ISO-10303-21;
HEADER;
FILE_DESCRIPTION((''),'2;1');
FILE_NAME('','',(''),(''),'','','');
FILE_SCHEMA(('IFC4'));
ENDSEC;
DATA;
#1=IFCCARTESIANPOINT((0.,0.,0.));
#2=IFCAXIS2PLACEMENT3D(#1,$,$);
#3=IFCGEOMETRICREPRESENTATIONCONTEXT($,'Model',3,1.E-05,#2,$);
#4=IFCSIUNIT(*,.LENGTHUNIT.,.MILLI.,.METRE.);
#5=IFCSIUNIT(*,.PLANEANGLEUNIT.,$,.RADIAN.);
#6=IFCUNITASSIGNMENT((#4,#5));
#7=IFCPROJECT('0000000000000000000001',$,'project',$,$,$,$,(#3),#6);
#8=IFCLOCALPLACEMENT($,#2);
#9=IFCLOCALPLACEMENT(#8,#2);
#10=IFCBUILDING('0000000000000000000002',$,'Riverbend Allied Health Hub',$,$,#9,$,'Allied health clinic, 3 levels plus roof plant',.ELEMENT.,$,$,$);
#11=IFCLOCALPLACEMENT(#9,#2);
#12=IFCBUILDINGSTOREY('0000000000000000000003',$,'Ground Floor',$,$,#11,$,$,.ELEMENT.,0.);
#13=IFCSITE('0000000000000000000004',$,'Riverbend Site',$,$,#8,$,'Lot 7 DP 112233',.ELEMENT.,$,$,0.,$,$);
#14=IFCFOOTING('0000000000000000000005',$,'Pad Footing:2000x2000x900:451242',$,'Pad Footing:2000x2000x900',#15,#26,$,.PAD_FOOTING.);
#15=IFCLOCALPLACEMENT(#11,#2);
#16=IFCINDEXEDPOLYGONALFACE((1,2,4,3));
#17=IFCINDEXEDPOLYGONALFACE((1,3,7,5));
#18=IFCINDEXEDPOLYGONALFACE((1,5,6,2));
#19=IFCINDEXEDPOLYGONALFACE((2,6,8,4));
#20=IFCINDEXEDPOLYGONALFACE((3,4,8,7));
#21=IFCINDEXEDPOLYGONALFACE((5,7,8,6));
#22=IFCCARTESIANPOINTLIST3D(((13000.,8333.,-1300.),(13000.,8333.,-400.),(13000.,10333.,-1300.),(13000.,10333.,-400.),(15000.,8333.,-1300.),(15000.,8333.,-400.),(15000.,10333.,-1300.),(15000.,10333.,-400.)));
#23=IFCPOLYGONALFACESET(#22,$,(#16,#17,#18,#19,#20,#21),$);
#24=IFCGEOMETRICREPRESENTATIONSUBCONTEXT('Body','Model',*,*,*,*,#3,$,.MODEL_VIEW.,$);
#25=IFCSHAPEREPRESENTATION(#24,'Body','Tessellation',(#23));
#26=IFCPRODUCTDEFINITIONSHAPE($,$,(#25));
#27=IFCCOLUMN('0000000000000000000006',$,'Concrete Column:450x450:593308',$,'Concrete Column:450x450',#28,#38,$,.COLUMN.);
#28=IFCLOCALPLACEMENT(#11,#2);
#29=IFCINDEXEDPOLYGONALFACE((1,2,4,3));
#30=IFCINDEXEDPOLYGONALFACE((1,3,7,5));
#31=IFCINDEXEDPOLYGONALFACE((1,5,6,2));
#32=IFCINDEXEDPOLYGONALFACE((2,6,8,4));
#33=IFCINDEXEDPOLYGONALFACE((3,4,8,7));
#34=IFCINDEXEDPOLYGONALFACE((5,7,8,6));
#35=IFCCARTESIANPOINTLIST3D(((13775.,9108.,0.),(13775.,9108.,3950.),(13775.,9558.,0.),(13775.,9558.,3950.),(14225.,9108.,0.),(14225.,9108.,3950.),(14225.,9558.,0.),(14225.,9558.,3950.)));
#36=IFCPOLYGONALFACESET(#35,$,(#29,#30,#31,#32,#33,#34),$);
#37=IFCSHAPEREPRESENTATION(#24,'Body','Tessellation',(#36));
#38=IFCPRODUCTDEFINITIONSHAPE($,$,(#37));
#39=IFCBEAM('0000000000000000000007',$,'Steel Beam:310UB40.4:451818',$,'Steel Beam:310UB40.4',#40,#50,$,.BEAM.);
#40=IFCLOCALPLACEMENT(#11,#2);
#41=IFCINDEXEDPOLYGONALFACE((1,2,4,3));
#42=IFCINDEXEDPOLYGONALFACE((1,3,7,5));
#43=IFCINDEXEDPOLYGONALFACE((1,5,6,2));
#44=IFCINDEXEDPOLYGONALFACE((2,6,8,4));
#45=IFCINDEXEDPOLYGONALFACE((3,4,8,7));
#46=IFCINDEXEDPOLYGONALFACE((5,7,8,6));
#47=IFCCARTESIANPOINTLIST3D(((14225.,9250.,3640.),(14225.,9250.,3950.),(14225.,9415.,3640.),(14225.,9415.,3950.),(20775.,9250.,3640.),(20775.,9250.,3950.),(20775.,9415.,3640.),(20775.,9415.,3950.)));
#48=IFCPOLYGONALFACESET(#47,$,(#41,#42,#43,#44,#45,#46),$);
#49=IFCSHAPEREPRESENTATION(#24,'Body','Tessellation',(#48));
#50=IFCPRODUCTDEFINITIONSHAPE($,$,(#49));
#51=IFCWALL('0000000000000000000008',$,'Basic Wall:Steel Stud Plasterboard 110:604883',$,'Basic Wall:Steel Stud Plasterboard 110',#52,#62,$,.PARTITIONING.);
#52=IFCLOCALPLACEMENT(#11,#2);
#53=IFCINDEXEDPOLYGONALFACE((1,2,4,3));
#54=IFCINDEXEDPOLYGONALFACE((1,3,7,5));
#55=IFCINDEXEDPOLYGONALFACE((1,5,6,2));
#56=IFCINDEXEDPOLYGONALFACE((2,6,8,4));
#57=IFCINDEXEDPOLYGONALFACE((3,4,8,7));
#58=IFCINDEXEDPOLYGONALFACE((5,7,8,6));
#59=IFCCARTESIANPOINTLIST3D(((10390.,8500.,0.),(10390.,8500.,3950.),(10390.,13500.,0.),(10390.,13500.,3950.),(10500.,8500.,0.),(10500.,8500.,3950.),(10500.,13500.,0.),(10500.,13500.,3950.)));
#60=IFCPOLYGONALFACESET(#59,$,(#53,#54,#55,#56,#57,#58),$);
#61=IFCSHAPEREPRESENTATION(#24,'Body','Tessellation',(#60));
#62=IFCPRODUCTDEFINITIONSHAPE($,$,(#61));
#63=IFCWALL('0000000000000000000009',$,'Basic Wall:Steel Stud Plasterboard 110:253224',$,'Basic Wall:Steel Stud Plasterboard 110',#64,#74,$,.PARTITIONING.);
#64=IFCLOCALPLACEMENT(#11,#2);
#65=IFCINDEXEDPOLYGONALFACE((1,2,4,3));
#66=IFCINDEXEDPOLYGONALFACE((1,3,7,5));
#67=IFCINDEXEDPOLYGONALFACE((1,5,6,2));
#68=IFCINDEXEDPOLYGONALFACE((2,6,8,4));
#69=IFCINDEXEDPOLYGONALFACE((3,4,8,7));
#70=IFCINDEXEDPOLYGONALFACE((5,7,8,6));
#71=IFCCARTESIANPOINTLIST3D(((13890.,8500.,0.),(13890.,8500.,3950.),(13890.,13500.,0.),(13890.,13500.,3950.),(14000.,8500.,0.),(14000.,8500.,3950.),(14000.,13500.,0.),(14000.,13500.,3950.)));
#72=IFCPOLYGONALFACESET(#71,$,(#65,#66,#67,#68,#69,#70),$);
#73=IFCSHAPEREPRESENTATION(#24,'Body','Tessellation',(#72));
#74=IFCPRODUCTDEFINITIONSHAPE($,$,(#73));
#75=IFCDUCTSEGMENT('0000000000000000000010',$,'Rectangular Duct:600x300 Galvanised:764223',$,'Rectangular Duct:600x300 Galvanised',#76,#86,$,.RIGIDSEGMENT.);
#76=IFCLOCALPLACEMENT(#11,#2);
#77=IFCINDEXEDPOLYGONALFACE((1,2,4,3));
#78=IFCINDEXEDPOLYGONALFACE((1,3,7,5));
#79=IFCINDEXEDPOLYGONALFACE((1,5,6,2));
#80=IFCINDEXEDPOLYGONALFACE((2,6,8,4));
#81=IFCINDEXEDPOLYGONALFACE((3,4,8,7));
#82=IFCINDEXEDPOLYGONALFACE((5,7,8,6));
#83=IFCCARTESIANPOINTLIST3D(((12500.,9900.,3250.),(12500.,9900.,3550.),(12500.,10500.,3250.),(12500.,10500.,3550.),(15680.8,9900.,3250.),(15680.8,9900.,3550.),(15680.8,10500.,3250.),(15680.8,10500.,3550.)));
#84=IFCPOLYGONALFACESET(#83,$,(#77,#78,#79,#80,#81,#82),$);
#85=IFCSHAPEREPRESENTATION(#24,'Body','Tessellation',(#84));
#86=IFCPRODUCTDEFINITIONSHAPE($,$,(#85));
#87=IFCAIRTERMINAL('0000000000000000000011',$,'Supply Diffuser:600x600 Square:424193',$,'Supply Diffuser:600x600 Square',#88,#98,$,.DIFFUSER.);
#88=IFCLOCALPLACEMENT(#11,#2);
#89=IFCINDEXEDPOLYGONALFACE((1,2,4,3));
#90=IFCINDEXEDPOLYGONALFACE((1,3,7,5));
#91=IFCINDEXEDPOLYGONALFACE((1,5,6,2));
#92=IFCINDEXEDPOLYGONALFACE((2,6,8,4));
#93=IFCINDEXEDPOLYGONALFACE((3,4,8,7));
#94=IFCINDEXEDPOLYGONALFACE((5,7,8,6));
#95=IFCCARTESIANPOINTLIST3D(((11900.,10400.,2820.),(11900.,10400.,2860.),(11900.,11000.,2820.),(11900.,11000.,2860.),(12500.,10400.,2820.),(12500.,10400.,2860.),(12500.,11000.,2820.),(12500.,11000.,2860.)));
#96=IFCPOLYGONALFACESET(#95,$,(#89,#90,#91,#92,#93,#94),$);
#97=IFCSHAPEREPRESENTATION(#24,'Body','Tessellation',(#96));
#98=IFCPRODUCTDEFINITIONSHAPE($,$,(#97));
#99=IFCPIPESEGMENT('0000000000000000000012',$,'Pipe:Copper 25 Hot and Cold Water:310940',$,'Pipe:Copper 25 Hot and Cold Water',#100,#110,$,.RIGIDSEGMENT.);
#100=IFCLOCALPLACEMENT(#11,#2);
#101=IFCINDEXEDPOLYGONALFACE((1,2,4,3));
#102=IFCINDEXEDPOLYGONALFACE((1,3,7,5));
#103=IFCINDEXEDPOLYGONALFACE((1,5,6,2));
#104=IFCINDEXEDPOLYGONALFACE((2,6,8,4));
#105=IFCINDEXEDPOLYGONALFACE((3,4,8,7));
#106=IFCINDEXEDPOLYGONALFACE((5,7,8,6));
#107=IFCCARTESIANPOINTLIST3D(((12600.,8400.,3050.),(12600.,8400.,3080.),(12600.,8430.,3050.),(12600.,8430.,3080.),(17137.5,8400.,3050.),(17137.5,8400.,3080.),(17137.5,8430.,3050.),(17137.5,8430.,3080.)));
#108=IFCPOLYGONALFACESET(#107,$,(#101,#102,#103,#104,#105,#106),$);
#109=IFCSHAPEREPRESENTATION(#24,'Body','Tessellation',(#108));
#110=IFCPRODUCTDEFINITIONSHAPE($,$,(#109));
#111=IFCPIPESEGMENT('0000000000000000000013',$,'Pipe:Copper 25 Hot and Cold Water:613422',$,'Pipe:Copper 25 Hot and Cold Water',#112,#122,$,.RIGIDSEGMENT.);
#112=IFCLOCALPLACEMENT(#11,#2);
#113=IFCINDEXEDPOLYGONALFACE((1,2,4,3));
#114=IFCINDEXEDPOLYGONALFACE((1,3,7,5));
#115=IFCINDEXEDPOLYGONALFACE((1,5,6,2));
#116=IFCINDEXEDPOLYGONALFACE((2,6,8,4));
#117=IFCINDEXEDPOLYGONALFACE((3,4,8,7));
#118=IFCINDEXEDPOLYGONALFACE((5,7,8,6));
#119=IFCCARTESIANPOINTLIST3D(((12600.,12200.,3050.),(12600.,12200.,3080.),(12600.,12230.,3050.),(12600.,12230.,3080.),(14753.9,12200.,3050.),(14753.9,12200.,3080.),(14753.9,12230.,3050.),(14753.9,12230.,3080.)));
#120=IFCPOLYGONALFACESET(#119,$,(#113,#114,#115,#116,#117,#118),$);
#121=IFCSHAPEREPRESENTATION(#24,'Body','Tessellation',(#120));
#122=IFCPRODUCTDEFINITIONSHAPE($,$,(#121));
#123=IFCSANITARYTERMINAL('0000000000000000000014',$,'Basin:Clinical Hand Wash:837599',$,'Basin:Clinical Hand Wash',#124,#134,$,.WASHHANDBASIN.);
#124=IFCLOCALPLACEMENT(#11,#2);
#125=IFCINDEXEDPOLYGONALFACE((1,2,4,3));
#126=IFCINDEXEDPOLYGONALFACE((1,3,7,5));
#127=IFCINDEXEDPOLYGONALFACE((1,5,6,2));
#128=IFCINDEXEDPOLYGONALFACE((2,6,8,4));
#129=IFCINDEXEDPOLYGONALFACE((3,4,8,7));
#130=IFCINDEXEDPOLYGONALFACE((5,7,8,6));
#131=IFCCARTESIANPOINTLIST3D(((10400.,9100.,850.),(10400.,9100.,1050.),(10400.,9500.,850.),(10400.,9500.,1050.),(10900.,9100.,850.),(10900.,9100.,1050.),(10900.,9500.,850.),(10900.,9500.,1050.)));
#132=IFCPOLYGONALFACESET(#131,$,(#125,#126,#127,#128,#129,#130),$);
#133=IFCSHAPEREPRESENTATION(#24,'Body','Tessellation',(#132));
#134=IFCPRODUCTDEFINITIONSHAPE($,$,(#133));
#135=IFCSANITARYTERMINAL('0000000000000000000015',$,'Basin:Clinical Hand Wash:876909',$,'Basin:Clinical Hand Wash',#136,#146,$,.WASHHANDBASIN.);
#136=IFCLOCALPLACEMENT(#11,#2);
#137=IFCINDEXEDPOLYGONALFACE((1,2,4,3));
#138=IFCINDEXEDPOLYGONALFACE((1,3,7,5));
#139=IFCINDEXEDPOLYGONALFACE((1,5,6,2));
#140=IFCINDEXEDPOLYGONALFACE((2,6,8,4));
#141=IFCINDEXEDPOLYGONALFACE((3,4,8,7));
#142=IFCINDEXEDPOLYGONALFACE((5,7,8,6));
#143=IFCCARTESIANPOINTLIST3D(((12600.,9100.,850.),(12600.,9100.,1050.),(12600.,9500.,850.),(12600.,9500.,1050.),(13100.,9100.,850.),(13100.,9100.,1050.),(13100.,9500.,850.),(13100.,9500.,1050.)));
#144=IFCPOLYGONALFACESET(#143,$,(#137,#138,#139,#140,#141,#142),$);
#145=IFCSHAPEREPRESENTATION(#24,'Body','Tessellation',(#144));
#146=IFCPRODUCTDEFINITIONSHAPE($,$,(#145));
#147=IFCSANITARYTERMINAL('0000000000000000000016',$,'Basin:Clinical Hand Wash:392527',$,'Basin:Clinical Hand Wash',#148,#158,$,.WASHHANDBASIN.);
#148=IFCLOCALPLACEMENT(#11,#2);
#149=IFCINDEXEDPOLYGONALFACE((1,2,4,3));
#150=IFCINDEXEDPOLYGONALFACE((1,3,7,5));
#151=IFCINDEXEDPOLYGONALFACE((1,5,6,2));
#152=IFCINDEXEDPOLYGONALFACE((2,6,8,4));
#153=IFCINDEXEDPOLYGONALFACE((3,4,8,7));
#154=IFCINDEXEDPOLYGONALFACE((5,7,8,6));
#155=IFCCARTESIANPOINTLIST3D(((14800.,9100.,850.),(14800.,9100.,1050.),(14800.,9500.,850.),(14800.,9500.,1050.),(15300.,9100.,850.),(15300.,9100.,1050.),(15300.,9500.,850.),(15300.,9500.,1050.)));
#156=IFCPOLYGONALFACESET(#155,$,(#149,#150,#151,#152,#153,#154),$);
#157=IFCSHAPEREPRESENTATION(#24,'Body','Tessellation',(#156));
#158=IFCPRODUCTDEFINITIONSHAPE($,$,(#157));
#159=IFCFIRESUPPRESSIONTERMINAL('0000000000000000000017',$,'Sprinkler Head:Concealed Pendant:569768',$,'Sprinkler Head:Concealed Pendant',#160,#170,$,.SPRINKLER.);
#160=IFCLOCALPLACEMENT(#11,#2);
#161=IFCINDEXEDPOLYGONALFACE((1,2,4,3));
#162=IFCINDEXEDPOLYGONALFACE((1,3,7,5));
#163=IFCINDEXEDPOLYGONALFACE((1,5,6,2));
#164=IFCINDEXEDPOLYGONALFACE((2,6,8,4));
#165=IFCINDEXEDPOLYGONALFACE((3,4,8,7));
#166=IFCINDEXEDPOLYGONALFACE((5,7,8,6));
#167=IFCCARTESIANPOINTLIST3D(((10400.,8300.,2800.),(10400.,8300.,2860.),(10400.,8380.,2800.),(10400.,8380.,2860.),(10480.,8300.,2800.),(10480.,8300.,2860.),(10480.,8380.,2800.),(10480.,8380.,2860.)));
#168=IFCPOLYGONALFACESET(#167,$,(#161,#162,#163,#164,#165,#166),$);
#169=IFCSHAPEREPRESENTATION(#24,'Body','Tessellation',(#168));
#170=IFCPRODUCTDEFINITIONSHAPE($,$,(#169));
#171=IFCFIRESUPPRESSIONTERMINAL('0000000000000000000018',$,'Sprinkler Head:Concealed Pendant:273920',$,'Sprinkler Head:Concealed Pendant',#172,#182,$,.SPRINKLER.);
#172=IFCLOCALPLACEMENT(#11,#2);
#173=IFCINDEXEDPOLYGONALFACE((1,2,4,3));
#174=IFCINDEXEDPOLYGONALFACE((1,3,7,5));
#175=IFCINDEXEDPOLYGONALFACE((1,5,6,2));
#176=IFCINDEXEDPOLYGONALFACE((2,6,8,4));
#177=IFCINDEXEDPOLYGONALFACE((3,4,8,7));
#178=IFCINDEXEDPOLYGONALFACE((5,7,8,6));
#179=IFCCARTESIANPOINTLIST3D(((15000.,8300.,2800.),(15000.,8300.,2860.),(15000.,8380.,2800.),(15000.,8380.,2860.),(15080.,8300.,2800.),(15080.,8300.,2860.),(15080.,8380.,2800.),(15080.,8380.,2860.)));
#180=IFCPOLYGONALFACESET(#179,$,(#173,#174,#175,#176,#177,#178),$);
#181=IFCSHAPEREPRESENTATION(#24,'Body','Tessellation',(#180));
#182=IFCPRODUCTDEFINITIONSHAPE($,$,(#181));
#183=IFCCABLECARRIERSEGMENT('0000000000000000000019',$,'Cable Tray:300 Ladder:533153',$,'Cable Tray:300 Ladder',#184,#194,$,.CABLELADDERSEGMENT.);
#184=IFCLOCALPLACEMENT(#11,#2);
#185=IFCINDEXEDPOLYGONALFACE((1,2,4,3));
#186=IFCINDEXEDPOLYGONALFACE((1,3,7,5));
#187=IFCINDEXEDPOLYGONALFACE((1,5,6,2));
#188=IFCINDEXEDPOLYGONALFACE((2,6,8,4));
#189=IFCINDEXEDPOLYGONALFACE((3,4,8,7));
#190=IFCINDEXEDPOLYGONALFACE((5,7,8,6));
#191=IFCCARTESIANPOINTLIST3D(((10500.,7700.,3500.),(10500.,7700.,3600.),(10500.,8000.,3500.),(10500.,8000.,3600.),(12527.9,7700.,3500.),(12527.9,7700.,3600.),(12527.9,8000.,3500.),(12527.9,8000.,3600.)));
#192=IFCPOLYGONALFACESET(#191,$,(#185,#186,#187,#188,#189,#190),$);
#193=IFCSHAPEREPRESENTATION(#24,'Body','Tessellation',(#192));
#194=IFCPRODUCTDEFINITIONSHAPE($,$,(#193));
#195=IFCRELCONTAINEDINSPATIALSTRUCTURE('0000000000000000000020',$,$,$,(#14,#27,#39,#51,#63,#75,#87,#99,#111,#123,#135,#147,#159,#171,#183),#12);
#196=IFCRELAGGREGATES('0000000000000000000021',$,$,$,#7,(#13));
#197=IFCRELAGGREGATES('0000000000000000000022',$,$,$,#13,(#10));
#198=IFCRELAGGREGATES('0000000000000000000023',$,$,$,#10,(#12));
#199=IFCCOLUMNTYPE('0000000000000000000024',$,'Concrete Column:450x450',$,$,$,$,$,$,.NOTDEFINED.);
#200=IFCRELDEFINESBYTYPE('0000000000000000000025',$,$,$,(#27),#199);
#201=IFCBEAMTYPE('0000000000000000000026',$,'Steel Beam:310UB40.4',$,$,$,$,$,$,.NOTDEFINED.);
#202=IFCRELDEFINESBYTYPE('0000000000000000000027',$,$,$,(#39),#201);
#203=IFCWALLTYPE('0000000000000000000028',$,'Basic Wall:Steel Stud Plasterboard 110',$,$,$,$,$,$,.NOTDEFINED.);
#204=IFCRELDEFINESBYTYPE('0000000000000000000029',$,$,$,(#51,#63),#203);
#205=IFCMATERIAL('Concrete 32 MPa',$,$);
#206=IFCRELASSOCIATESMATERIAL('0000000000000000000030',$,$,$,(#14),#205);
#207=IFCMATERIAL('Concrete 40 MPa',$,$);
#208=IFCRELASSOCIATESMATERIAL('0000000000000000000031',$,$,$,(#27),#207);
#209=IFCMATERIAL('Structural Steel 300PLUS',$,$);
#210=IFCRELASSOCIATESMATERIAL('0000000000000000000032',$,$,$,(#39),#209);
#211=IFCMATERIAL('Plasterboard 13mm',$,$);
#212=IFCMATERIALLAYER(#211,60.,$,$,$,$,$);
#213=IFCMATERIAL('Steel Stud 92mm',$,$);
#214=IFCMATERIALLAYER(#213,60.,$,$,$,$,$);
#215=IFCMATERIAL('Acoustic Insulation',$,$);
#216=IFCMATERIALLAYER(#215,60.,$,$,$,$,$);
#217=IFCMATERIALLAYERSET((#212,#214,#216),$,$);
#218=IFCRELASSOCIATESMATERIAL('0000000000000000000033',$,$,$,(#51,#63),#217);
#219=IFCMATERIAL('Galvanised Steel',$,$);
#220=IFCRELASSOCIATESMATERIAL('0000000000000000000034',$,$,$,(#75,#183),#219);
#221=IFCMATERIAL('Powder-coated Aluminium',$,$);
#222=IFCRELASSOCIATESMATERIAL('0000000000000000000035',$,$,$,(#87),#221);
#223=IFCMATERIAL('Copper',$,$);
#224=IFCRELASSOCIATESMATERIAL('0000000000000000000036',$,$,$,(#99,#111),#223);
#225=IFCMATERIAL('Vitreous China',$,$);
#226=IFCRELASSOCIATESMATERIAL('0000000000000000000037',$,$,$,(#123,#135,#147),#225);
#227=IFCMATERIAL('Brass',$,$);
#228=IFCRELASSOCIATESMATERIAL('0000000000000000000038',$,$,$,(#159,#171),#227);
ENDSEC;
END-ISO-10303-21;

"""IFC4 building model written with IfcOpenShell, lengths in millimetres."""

from ifc_helpers import new_model, si_unit, frame, frame_2d, origin, place, context, subcontext, project, spatial, rectangle, extrude, material, layer, layer_set, layer_usage, type_object, element, save


model = new_model("IFC4")

# Units and contexts
model_context = context("Model", 3, precision=1e-05, world=origin())
body_context = subcontext(model_context, "Body", "Model", "MODEL_VIEW")
ifc_project = project(units=[si_unit("LENGTHUNIT", "METRE", prefix="MILLI"), si_unit("PLANEANGLEUNIT", "RADIAN")], contexts=[model_context])

# Site, building, storey
site_placement = place(None, origin())
site = spatial("IfcSite", under=ifc_project, at=site_placement, Name="Riverbend Site", LongName="Lot 7 DP 112233", CompositionType="ELEMENT", RefElevation=0.0)
building_placement = place(site_placement, origin())
building = spatial("IfcBuilding", under=site, at=building_placement, Name="Riverbend Allied Health Hub", LongName="Allied health clinic, 3 levels plus roof plant", CompositionType="ELEMENT")
storey_placement = place(building_placement, origin())
storey = spatial("IfcBuildingStorey", under=building, at=storey_placement, Name="Ground Floor", CompositionType="ELEMENT", Elevation=0.0)

# Footing
ifc_material_1 = material(Name="Concrete 32 MPa")
footing_placement = place(storey_placement, frame((13000.0, 8333.0, -1300.0)))
element("IfcFooting", 1, at=footing_placement, inside=storey, material=ifc_material_1, Name="Pad Footing:2000x2000x900:451242", ObjectType="Pad Footing:2000x2000x900", PredefinedType="PAD_FOOTING", context=body_context, shape_type="SweptSolid", body=[
    extrude(rectangle(XDim=2000.0, YDim=2000.0, at=frame_2d((1000.0, 1000.0))), origin(), (0.0, 0.0, 1.0), 900.0),
])

# Column
ifc_material_2 = material(Name="Concrete 40 MPa")
column_type = type_object("IfcColumnType", Name="Concrete Column:450x450", PredefinedType="NOTDEFINED")
column_placement = place(storey_placement, frame((13775.0, 9108.0, 0.0)))
element("IfcColumn", 2, at=column_placement, inside=storey, type_object=column_type, material=ifc_material_2, Name="Concrete Column:450x450:593308", ObjectType="Concrete Column:450x450", PredefinedType="COLUMN", context=body_context, shape_type="SweptSolid", body=[
    extrude(rectangle(XDim=450.0, YDim=450.0, at=frame_2d((225.0, 225.0))), origin(), (0.0, 0.0, 1.0), 3950.0),
])

# Beam
ifc_material_3 = material(Name="Structural Steel 300PLUS")
beam_type = type_object("IfcBeamType", Name="Steel Beam:310UB40.4", PredefinedType="NOTDEFINED")
beam_placement = place(storey_placement, frame((14225.0, 9250.0, 3640.0)))
element("IfcBeam", 3, at=beam_placement, inside=storey, type_object=beam_type, material=ifc_material_3, Name="Steel Beam:310UB40.4:451818", ObjectType="Steel Beam:310UB40.4", PredefinedType="BEAM", context=body_context, shape_type="SweptSolid", body=[
    extrude(rectangle(XDim=6550.0, YDim=165.0, at=frame_2d((3275.0, 82.5))), origin(), (0.0, 0.0, 1.0), 310.0),
])

# Walls
ifc_material_4 = material(Name="Plasterboard 13mm")
ifc_layer_1 = layer(ifc_material_4, 60.0)
ifc_material_5 = material(Name="Steel Stud 92mm")
ifc_layer_2 = layer(ifc_material_5, 60.0)
ifc_material_6 = material(Name="Acoustic Insulation")
ifc_layer_3 = layer(ifc_material_6, 60.0)
ifc_layer_set = layer_set([ifc_layer_1, ifc_layer_2, ifc_layer_3])
ifc_layer_usage = layer_usage(ifc_layer_set, "AXIS2", "POSITIVE", 0.0)
wall_type = type_object("IfcWallType", Name="Basic Wall:Steel Stud Plasterboard 110", PredefinedType="NOTDEFINED")
for number, where, z_axis, x_axis, name in (
    (4, (10500.0, 8500.0, 0.0), (0.0, 0.0, 1.0), (0.0, 1.0, 0.0), "Basic Wall:Steel Stud Plasterboard 110:604883"),
    (5, (14000.0, 8500.0, 0.0), (0.0, 0.0, 1.0), (0.0, 1.0, 0.0), "Basic Wall:Steel Stud Plasterboard 110:253224"),
):
    element("IfcWall", number, at=place(storey_placement, frame(where, z_axis=z_axis, x_axis=x_axis)), inside=storey, type_object=wall_type, material=ifc_layer_usage, Name=name, ObjectType="Basic Wall:Steel Stud Plasterboard 110", PredefinedType="PARTITIONING", context=body_context, shape_type="SweptSolid", body=[
        extrude(rectangle(XDim=5000.0, YDim=110.0, at=frame_2d((2500.0, 55.0))), origin(), (0.0, 0.0, 1.0), 3950.0),
    ])

# Duct segment
ifc_material_7 = material(Name="Galvanised Steel")
duct_segment_placement = place(storey_placement, frame((12500.0, 9900.0, 3250.0)))
element("IfcDuctSegment", 6, at=duct_segment_placement, inside=storey, material=ifc_material_7, Name="Rectangular Duct:600x300 Galvanised:764223", ObjectType="Rectangular Duct:600x300 Galvanised", PredefinedType="RIGIDSEGMENT", context=body_context, shape_type="SweptSolid", body=[
    extrude(rectangle(XDim=3180.8, YDim=600.0, at=frame_2d((1590.4, 300.0))), origin(), (0.0, 0.0, 1.0), 300.0),
])

# Air terminal
ifc_material_8 = material(Name="Powder-coated Aluminium")
air_terminal_placement = place(storey_placement, frame((11900.0, 10400.0, 2820.0)))
element("IfcAirTerminal", 7, at=air_terminal_placement, inside=storey, material=ifc_material_8, Name="Supply Diffuser:600x600 Square:424193", ObjectType="Supply Diffuser:600x600 Square", PredefinedType="DIFFUSER", context=body_context, shape_type="SweptSolid", body=[
    extrude(rectangle(XDim=600.0, YDim=600.0, at=frame_2d((300.0, 300.0))), origin(), (0.0, 0.0, 1.0), 40.0),
])

# Pipe segments
ifc_material_9 = material(Name="Copper")
pipe_segment_1_placement = place(storey_placement, frame((12600.0, 8400.0, 3050.0)))
element("IfcPipeSegment", 8, at=pipe_segment_1_placement, inside=storey, material=ifc_material_9, Name="Pipe:Copper 25 Hot and Cold Water:310940", ObjectType="Pipe:Copper 25 Hot and Cold Water", PredefinedType="RIGIDSEGMENT", context=body_context, shape_type="SweptSolid", body=[
    extrude(rectangle(XDim=4537.5, YDim=30.0, at=frame_2d((2268.8, 15.0))), origin(), (0.0, 0.0, 1.0), 30.0),
])
pipe_segment_2_placement = place(storey_placement, frame((12600.0, 12200.0, 3050.0)))
element("IfcPipeSegment", 9, at=pipe_segment_2_placement, inside=storey, material=ifc_material_9, Name="Pipe:Copper 25 Hot and Cold Water:613422", ObjectType="Pipe:Copper 25 Hot and Cold Water", PredefinedType="RIGIDSEGMENT", context=body_context, shape_type="SweptSolid", body=[
    extrude(rectangle(XDim=2153.9, YDim=30.0, at=frame_2d((1076.9, 15.0))), origin(), (0.0, 0.0, 1.0), 30.0),
])

# Sanitary terminals
ifc_material_10 = material(Name="Vitreous China")
for number, where, name in (
    (10, (10400.0, 9100.0, 850.0), "Basin:Clinical Hand Wash:837599"),
    (11, (12600.0, 9100.0, 850.0), "Basin:Clinical Hand Wash:876909"),
    (12, (14800.0, 9100.0, 850.0), "Basin:Clinical Hand Wash:392527"),
):
    element("IfcSanitaryTerminal", number, at=place(storey_placement, frame(where)), inside=storey, material=ifc_material_10, Name=name, ObjectType="Basin:Clinical Hand Wash", PredefinedType="WASHHANDBASIN", context=body_context, shape_type="SweptSolid", body=[
        extrude(rectangle(XDim=500.0, YDim=400.0, at=frame_2d((250.0, 200.0))), origin(), (0.0, 0.0, 1.0), 200.0),
    ])

# Fire suppression terminals
ifc_material_11 = material(Name="Brass")
for number, where, name in (
    (13, (10400.0, 8300.0, 2800.0), "Sprinkler Head:Concealed Pendant:569768"),
    (14, (15000.0, 8300.0, 2800.0), "Sprinkler Head:Concealed Pendant:273920"),
):
    element("IfcFireSuppressionTerminal", number, at=place(storey_placement, frame(where)), inside=storey, material=ifc_material_11, Name=name, ObjectType="Sprinkler Head:Concealed Pendant", PredefinedType="SPRINKLER", context=body_context, shape_type="SweptSolid", body=[
        extrude(rectangle(XDim=80.0, YDim=80.0, at=frame_2d((40.0, 40.0))), origin(), (0.0, 0.0, 1.0), 60.0),
    ])

# Cable carrier segment
cable_carrier_segment_1_placement = place(storey_placement, frame((10500.0, 7700.0, 3500.0)))
element("IfcCableCarrierSegment", 15, at=cable_carrier_segment_1_placement, inside=storey, material=ifc_material_7, Name="Cable Tray:300 Ladder:533153", ObjectType="Cable Tray:300 Ladder", PredefinedType="CABLELADDERSEGMENT", context=body_context, shape_type="SweptSolid", body=[
    extrude(rectangle(XDim=2027.9, YDim=300.0, at=frame_2d((1014.0, 150.0))), origin(), (0.0, 0.0, 1.0), 100.0),
])

save(model, "model.ifc")
